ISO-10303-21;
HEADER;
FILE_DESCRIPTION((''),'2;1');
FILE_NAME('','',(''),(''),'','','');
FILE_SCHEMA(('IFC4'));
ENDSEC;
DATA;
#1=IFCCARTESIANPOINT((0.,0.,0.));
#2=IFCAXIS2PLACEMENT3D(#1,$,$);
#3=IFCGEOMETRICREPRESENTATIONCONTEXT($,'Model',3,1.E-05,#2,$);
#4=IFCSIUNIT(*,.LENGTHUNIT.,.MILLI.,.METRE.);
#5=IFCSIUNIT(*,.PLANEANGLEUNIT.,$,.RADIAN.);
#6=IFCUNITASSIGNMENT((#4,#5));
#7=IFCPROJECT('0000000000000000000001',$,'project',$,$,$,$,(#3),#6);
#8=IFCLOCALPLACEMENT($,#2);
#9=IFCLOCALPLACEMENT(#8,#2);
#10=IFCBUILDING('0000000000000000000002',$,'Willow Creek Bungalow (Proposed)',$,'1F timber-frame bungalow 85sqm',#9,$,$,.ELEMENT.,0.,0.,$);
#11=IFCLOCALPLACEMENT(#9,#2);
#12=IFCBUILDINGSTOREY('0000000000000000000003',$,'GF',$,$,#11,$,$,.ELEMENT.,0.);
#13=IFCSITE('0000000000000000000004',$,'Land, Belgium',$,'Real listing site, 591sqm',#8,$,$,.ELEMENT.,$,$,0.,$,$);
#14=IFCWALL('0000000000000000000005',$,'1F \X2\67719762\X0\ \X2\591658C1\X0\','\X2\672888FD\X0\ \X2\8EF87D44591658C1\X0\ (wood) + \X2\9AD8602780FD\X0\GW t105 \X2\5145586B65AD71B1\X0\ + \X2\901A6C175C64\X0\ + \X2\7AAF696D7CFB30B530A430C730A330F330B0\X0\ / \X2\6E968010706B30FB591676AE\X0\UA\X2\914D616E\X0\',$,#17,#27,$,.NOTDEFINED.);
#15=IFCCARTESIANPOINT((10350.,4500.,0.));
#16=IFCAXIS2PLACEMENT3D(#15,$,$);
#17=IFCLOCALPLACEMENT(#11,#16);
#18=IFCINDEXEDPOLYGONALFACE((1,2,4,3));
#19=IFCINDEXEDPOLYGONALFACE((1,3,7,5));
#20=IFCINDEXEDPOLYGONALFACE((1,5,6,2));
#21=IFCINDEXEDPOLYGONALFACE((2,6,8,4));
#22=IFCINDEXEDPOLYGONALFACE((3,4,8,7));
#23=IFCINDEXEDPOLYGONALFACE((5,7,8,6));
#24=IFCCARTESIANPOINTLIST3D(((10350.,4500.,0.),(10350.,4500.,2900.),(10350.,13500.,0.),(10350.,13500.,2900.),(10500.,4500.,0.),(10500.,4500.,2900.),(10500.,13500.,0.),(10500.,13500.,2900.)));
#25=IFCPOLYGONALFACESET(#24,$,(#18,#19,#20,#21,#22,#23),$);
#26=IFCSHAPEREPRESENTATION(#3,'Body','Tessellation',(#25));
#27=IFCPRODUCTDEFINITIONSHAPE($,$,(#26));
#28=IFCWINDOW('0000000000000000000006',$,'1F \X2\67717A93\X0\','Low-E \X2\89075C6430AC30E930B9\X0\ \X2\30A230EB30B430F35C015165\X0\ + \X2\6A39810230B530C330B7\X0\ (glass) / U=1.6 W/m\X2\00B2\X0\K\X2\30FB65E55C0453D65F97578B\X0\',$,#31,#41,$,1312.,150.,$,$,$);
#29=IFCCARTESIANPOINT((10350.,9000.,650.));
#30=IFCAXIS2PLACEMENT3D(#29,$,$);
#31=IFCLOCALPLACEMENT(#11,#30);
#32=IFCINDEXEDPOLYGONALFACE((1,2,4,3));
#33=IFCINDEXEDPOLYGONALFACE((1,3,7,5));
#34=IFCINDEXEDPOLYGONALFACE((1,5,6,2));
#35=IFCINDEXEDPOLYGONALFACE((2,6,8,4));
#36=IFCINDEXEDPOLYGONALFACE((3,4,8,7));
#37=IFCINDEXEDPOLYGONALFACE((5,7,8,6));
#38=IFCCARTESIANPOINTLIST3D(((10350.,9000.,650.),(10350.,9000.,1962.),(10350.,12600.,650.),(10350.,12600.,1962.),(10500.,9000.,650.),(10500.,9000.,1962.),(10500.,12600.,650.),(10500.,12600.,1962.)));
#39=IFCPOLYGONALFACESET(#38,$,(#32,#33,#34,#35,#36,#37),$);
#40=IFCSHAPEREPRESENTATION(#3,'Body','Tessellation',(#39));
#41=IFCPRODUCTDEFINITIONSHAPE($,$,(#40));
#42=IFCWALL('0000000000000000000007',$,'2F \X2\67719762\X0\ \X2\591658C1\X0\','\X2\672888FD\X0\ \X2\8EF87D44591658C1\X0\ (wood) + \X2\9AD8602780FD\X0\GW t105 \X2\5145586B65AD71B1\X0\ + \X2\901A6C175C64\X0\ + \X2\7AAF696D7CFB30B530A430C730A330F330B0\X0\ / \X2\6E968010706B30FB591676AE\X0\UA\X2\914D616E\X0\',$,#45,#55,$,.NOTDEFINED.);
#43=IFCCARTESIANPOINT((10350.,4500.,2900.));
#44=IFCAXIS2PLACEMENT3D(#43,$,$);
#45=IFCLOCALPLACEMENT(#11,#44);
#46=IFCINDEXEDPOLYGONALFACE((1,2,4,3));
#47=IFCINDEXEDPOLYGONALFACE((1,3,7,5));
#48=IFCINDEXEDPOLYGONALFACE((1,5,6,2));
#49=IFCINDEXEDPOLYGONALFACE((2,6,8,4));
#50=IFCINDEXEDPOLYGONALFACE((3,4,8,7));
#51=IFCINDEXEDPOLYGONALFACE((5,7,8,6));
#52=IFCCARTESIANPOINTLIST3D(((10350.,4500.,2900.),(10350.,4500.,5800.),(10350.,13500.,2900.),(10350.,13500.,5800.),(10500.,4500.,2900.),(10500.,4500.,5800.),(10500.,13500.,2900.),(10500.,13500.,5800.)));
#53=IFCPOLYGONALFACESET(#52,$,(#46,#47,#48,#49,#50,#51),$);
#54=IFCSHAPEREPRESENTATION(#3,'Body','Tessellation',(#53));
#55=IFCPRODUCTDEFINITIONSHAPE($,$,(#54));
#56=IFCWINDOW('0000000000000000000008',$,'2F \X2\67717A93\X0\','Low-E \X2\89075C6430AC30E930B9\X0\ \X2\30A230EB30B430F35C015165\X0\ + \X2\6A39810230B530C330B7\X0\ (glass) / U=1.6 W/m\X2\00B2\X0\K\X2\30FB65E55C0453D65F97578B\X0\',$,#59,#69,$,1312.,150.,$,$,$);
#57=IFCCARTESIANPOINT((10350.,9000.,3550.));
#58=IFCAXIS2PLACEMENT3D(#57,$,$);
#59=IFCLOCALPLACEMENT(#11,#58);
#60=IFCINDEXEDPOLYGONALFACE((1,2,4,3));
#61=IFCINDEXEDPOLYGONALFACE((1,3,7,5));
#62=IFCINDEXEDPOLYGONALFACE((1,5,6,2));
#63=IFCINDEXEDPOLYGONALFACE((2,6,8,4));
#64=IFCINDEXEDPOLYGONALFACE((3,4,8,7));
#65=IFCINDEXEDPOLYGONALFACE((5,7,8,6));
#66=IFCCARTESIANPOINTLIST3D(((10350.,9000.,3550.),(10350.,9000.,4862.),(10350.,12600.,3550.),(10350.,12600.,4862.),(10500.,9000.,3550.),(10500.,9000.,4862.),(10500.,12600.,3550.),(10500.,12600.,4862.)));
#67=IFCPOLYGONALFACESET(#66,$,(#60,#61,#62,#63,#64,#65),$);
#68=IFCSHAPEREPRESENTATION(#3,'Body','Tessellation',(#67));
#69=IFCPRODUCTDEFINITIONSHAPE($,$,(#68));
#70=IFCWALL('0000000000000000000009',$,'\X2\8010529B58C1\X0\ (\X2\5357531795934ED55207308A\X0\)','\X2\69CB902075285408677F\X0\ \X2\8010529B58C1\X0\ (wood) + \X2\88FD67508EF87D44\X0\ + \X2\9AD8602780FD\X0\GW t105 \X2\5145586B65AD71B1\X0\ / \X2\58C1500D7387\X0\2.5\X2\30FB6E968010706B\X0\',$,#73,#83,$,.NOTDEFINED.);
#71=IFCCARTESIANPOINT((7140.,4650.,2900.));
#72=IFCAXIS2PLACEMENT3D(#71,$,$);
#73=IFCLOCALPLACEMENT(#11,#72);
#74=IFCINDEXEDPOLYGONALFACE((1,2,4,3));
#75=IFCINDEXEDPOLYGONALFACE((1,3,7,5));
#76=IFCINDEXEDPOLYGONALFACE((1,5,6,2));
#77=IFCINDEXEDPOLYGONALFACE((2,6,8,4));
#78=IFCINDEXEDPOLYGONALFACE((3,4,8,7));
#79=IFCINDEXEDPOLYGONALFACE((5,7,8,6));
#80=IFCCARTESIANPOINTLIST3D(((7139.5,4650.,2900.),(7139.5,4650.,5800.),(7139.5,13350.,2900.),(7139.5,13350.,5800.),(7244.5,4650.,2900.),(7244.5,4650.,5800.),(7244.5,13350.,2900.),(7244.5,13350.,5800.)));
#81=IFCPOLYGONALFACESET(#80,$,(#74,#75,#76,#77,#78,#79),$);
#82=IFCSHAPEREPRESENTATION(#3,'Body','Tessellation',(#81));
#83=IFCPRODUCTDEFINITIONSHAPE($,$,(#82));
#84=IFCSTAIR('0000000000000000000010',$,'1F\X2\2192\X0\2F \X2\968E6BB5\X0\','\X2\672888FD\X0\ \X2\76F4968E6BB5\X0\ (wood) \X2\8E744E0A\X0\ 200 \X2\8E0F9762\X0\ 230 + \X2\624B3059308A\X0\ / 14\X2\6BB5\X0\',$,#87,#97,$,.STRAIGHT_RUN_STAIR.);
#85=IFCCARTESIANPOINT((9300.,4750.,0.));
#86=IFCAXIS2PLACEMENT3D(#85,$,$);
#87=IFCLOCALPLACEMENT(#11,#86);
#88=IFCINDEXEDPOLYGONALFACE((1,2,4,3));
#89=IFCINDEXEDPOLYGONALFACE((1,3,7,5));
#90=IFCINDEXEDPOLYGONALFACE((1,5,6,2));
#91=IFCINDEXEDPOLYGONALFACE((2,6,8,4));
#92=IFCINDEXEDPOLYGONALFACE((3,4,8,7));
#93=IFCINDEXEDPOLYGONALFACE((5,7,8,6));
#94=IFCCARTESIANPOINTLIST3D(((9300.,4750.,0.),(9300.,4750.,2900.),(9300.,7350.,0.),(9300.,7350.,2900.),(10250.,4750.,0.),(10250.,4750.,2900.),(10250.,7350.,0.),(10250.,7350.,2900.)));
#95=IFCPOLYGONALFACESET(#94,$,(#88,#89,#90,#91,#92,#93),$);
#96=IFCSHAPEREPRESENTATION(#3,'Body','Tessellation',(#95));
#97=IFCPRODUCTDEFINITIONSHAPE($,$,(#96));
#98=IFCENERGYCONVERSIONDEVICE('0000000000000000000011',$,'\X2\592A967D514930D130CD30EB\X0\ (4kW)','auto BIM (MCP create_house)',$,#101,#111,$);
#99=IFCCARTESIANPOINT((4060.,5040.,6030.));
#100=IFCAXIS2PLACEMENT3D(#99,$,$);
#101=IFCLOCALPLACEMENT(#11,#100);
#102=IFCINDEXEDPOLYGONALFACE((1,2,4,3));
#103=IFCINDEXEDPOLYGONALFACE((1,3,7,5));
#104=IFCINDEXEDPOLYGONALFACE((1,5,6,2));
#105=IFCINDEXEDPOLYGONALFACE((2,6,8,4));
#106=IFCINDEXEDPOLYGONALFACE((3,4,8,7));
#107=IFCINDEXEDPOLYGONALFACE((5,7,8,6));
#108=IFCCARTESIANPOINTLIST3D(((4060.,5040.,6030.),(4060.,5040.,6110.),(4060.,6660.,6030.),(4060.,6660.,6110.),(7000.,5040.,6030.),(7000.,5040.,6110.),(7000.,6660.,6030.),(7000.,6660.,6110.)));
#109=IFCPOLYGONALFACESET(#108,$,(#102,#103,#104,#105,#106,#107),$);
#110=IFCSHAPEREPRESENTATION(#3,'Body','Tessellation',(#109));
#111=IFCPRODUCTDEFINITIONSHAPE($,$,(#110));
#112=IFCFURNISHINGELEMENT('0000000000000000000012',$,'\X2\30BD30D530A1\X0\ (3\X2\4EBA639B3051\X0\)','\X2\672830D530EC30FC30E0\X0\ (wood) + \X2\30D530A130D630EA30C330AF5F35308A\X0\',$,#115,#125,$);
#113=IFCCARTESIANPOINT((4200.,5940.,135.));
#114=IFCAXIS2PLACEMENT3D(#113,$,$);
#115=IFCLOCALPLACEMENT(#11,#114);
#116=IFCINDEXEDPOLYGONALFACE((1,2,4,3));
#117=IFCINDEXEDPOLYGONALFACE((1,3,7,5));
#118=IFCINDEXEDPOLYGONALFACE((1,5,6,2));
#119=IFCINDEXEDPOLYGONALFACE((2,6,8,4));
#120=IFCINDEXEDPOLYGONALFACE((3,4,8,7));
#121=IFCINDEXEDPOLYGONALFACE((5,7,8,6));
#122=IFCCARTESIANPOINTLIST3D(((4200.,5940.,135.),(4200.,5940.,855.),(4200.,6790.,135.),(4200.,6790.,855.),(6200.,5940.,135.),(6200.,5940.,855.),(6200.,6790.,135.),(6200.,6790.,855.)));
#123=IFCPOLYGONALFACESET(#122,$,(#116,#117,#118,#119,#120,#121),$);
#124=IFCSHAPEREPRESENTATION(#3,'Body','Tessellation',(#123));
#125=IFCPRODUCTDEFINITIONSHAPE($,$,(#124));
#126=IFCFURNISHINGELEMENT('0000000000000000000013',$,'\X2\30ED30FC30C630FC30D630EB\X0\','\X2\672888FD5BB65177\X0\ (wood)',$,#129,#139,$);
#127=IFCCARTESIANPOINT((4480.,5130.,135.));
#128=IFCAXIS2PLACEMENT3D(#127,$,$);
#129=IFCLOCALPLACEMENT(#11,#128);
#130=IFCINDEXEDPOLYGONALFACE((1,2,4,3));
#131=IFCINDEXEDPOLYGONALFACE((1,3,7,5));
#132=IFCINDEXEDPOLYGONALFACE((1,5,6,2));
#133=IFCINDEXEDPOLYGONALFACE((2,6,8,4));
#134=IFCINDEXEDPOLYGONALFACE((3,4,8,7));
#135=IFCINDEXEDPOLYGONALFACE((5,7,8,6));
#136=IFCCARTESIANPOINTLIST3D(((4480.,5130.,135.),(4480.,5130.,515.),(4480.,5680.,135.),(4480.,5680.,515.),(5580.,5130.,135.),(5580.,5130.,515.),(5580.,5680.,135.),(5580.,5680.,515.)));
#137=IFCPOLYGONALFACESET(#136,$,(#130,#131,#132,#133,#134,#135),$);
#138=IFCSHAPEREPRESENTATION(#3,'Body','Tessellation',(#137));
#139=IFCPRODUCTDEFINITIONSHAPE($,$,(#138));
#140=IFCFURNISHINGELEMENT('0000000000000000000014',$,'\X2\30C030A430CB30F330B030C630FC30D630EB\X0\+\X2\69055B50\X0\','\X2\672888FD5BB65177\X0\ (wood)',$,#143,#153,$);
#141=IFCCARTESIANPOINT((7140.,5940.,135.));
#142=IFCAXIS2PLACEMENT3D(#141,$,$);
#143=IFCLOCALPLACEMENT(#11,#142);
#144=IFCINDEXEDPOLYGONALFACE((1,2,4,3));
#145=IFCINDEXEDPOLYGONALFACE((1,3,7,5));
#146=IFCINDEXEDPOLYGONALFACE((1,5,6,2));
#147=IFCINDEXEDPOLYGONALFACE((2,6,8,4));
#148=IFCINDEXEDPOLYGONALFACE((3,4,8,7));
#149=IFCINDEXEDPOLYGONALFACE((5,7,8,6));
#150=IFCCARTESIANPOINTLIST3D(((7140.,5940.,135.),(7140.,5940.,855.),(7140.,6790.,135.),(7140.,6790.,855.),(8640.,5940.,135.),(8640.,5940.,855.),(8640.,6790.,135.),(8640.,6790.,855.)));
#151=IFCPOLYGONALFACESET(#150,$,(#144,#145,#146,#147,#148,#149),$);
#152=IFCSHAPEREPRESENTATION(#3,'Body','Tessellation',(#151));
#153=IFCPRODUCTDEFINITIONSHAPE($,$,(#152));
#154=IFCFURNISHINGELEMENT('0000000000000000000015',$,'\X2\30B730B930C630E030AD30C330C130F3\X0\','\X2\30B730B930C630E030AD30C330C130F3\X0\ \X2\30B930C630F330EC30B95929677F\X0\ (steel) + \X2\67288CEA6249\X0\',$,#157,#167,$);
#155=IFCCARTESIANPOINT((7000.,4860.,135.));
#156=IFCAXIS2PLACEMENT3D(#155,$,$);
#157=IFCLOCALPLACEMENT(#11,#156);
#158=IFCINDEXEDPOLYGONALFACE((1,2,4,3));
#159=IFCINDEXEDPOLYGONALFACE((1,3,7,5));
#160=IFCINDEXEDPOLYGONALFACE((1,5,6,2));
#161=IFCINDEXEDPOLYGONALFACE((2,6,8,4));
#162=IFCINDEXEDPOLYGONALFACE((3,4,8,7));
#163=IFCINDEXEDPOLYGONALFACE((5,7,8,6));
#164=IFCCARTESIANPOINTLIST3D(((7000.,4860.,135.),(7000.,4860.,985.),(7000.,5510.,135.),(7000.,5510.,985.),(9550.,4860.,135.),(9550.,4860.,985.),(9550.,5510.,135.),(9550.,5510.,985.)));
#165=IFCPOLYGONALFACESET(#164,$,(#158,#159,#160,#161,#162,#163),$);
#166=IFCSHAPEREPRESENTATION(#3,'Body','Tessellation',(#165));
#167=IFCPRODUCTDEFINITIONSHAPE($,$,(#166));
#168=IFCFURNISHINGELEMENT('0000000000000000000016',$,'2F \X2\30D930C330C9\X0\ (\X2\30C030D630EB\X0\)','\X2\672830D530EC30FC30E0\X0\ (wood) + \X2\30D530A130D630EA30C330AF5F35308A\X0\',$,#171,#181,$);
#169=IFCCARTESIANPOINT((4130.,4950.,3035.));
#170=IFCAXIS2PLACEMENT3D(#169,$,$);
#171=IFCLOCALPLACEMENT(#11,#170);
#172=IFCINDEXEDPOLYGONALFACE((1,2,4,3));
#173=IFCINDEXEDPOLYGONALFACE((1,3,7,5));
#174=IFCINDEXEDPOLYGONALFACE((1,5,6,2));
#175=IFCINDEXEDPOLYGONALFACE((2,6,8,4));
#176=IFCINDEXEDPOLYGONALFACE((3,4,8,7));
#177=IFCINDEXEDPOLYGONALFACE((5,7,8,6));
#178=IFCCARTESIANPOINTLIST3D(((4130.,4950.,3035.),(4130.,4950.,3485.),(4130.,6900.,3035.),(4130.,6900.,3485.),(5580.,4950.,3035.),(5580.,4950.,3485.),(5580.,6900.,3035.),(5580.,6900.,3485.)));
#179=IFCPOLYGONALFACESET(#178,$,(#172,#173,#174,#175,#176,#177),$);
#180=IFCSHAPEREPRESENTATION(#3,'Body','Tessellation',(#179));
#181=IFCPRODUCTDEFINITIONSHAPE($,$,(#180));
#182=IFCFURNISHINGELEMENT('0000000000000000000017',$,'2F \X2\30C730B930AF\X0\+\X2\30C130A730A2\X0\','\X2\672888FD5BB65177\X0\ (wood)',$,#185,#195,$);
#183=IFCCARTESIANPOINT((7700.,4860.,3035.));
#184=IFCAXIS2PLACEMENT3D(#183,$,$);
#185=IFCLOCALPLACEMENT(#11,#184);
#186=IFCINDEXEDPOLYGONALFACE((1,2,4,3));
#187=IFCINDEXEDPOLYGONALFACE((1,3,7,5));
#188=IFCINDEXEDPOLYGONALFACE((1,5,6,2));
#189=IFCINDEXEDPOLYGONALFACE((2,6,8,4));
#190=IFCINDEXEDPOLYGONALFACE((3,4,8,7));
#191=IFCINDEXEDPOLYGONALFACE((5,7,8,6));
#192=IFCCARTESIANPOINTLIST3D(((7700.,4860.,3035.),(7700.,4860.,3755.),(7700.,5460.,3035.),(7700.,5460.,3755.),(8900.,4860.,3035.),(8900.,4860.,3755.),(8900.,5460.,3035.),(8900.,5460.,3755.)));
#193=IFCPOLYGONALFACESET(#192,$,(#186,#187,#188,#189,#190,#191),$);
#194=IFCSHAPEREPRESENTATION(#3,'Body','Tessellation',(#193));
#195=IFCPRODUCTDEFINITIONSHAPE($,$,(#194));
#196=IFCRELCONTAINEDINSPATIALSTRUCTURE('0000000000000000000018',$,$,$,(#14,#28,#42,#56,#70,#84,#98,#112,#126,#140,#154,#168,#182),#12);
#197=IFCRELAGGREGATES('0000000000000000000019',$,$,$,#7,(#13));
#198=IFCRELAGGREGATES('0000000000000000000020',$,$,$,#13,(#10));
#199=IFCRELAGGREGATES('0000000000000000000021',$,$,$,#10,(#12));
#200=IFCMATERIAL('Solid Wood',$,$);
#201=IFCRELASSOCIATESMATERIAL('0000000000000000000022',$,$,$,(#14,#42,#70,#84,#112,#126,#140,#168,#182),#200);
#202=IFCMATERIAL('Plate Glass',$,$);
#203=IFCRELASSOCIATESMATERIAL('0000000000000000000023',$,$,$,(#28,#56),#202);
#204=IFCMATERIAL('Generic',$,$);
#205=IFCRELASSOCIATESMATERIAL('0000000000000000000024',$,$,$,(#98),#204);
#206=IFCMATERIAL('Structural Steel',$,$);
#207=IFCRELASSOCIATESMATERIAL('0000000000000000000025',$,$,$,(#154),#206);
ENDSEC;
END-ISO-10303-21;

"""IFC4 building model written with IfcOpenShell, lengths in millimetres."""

from ifc_helpers import new_model, si_unit, frame, frame_2d, origin, place, context, project, spatial, rectangle, extrude, material, element, fill, save


model = new_model("IFC4")

# Units and contexts
model_context = context("Model", 3, precision=1e-05, world=origin())
ifc_project = project(units=[si_unit("LENGTHUNIT", "METRE", prefix="MILLI"), si_unit("PLANEANGLEUNIT", "RADIAN")], contexts=[model_context])

# Site, building, storey
site_placement = place(None, origin())
site = spatial("IfcSite", under=ifc_project, at=site_placement, Name="Land, Belgium", ObjectType="Real listing site, 591sqm", CompositionType="ELEMENT", RefElevation=0.0)
building_placement = place(site_placement, origin())
building = spatial("IfcBuilding", under=site, at=building_placement, Name="Willow Creek Bungalow (Proposed)", ObjectType="1F timber-frame bungalow 85sqm", CompositionType="ELEMENT", ElevationOfRefHeight=0.0, ElevationOfTerrain=0.0)
storey_placement = place(building_placement, origin())
storey = spatial("IfcBuildingStorey", under=building, at=storey_placement, Name="GF", CompositionType="ELEMENT", Elevation=0.0)

# Wall, opening, window
ifc_material_1 = material(Name="Solid Wood")
wall_1_placement = place(storey_placement, frame((10350.0, 4500.0, 0.0)))
wall_1 = element("IfcWall", 1, at=wall_1_placement, inside=storey, material=ifc_material_1, Name="1F 東面 外壁", Description="木製 軸組外壁 (wood) + 高性能GW t105 充填断熱 + 通気層 + 窯業系サイディング / 準耐火・外皮UA配慮", PredefinedType="NOTDEFINED", context=model_context, shape_type="SweptSolid", body=[
    extrude(rectangle(XDim=150.0, YDim=9000.0, at=frame_2d((75.0, 4500.0))), frame((10350.0, 4500.0, 0.0)), (0.0, 0.0, 1.0), 2900.0),
])
opening_1_placement = place(storey_placement, frame((10350.0, 9000.0, 650.0)))
opening_1 = element("IfcOpeningElement", 2, at=opening_1_placement, cuts=wall_1, PredefinedType="NOTDEFINED", context=model_context, shape_type="SweptSolid", body=[
    extrude(rectangle(XDim=150.0, YDim=3600.0, at=frame_2d((75.0, 1800.0))), frame((10350.0, 9000.0, 650.0)), (0.0, 0.0, 1.0), 1312.0),
])
ifc_material_2 = material(Name="Plate Glass")
window_1_placement = place(storey_placement, frame((10350.0, 9000.0, 650.0)))
window_1 = element("IfcWindow", 3, at=window_1_placement, inside=storey, material=ifc_material_2, Name="1F 東窓", Description="Low-E 複層ガラス アルゴン封入 + 樹脂サッシ (glass) / U=1.6 W/m²K・日射取得型", OverallHeight=1312.0, OverallWidth=150.0, context=model_context, shape_type="SweptSolid", body=[
    extrude(rectangle(XDim=150.0, YDim=3600.0, at=frame_2d((75.0, 1800.0))), frame((10350.0, 9000.0, 650.0)), (0.0, 0.0, 1.0), 1312.0),
])
fill(opening_1, window_1)

# Wall, opening, window
wall_2_placement = place(storey_placement, frame((10350.0, 4500.0, 2900.0)))
wall_2 = element("IfcWall", 4, at=wall_2_placement, inside=storey, material=ifc_material_1, Name="2F 東面 外壁", Description="木製 軸組外壁 (wood) + 高性能GW t105 充填断熱 + 通気層 + 窯業系サイディング / 準耐火・外皮UA配慮", PredefinedType="NOTDEFINED", context=model_context, shape_type="SweptSolid", body=[
    extrude(rectangle(XDim=150.0, YDim=9000.0, at=frame_2d((75.0, 4500.0))), frame((10350.0, 4500.0, 2900.0)), (0.0, 0.0, 1.0), 2900.0),
])
opening_2_placement = place(storey_placement, frame((10350.0, 9000.0, 3550.0)))
opening_2 = element("IfcOpeningElement", 5, at=opening_2_placement, cuts=wall_2, PredefinedType="NOTDEFINED", context=model_context, shape_type="SweptSolid", body=[
    extrude(rectangle(XDim=150.0, YDim=3600.0, at=frame_2d((75.0, 1800.0))), frame((10350.0, 9000.0, 3550.0)), (0.0, 0.0, 1.0), 1312.0),
])
window_2_placement = place(storey_placement, frame((10350.0, 9000.0, 3550.0)))
window_2 = element("IfcWindow", 6, at=window_2_placement, inside=storey, material=ifc_material_2, Name="2F 東窓", Description="Low-E 複層ガラス アルゴン封入 + 樹脂サッシ (glass) / U=1.6 W/m²K・日射取得型", OverallHeight=1312.0, OverallWidth=150.0, context=model_context, shape_type="SweptSolid", body=[
    extrude(rectangle(XDim=150.0, YDim=3600.0, at=frame_2d((75.0, 1800.0))), frame((10350.0, 9000.0, 3550.0)), (0.0, 0.0, 1.0), 1312.0),
])
fill(opening_2, window_2)

# Wall
wall_3_placement = place(storey_placement, frame((7140.0, 4650.0, 2900.0)))
element("IfcWall", 7, at=wall_3_placement, inside=storey, material=ifc_material_1, Name="耐力壁 (南北間仕切り)", Description="構造用合板 耐力壁 (wood) + 製材軸組 + 高性能GW t105 充填断熱 / 壁倍率2.5・準耐火", PredefinedType="NOTDEFINED", context=model_context, shape_type="SweptSolid", body=[
    extrude(rectangle(XDim=105.0, YDim=8700.0, at=frame_2d((52.0, 4350.0))), frame((7140.0, 4650.0, 2900.0)), (0.0, 0.0, 1.0), 2900.0),
])

# Stair
stair_placement = place(storey_placement, frame((9300.0, 4750.0, 0.0)))
element("IfcStair", 8, at=stair_placement, inside=storey, material=ifc_material_1, Name="1F→2F 階段", Description="木製 直階段 (wood) 蹴上 200 踏面 230 + 手すり / 14段", PredefinedType="STRAIGHT_RUN_STAIR", context=model_context, shape_type="SweptSolid", body=[
    extrude(rectangle(XDim=950.0, YDim=2600.0, at=frame_2d((475.0, 1300.0))), frame((9300.0, 4750.0, 0.0)), (0.0, 0.0, 1.0), 2900.0),
])

# Energy conversion device
ifc_material_3 = material(Name="Generic")
energy_conversion_device_placement = place(storey_placement, frame((4060.0, 5040.0, 6030.0)))
element("IfcEnergyConversionDevice", 9, at=energy_conversion_device_placement, inside=storey, material=ifc_material_3, Name="太陽光パネル (4kW)", Description="auto BIM (MCP create_house)", context=model_context, shape_type="SweptSolid", body=[
    extrude(rectangle(XDim=2940.0, YDim=1620.0, at=frame_2d((1470.0, 810.0))), frame((4060.0, 5040.0, 6030.0)), (0.0, 0.0, 1.0), 80.0),
])

# Furnishing elements
furnishing_1_placement = place(storey_placement, frame((4200.0, 5940.0, 135.0)))
element("IfcFurnishingElement", 10, at=furnishing_1_placement, inside=storey, material=ifc_material_1, Name="ソファ (3人掛け)", Description="木フレーム (wood) + ファブリック張り", context=model_context, shape_type="SweptSolid", body=[
    extrude(rectangle(XDim=2000.0, YDim=850.0, at=frame_2d((1000.0, 425.0))), frame((4200.0, 5940.0, 135.0)), (0.0, 0.0, 1.0), 720.0),
])
furnishing_2_placement = place(storey_placement, frame((4480.0, 5130.0, 135.0)))
element("IfcFurnishingElement", 11, at=furnishing_2_placement, inside=storey, material=ifc_material_1, Name="ローテーブル", Description="木製家具 (wood)", context=model_context, shape_type="SweptSolid", body=[
    extrude(rectangle(XDim=1100.0, YDim=550.0, at=frame_2d((550.0, 275.0))), frame((4480.0, 5130.0, 135.0)), (0.0, 0.0, 1.0), 380.0),
])
furnishing_3_placement = place(storey_placement, frame((7140.0, 5940.0, 135.0)))
element("IfcFurnishingElement", 12, at=furnishing_3_placement, inside=storey, material=ifc_material_1, Name="ダイニングテーブル+椅子", Description="木製家具 (wood)", context=model_context, shape_type="SweptSolid", body=[
    extrude(rectangle(XDim=1500.0, YDim=850.0, at=frame_2d((750.0, 425.0))), frame((7140.0, 5940.0, 135.0)), (0.0, 0.0, 1.0), 720.0),
])
ifc_material_4 = material(Name="Structural Steel")
furnishing_4_placement = place(storey_placement, frame((7000.0, 4860.0, 135.0)))
element("IfcFurnishingElement", 13, at=furnishing_4_placement, inside=storey, material=ifc_material_4, Name="システムキッチン", Description="システムキッチン ステンレス天板 (steel) + 木質扉", context=model_context, shape_type="SweptSolid", body=[
    extrude(rectangle(XDim=2550.0, YDim=650.0, at=frame_2d((1275.0, 325.0))), frame((7000.0, 4860.0, 135.0)), (0.0, 0.0, 1.0), 850.0),
])
furnishing_5_placement = place(storey_placement, frame((4130.0, 4950.0, 3035.0)))
element("IfcFurnishingElement", 14, at=furnishing_5_placement, inside=storey, material=ifc_material_1, Name="2F ベッド (ダブル)", Description="木フレーム (wood) + ファブリック張り", context=model_context, shape_type="SweptSolid", body=[
    extrude(rectangle(XDim=1450.0, YDim=1950.0, at=frame_2d((725.0, 975.0))), frame((4130.0, 4950.0, 3035.0)), (0.0, 0.0, 1.0), 450.0),
])
furnishing_6_placement = place(storey_placement, frame((7700.0, 4860.0, 3035.0)))
element("IfcFurnishingElement", 15, at=furnishing_6_placement, inside=storey, material=ifc_material_1, Name="2F デスク+チェア", Description="木製家具 (wood)", context=model_context, shape_type="SweptSolid", body=[
    extrude(rectangle(XDim=1200.0, YDim=600.0, at=frame_2d((600.0, 300.0))), frame((7700.0, 4860.0, 3035.0)), (0.0, 0.0, 1.0), 720.0),
])

save(model, "model.ifc")
